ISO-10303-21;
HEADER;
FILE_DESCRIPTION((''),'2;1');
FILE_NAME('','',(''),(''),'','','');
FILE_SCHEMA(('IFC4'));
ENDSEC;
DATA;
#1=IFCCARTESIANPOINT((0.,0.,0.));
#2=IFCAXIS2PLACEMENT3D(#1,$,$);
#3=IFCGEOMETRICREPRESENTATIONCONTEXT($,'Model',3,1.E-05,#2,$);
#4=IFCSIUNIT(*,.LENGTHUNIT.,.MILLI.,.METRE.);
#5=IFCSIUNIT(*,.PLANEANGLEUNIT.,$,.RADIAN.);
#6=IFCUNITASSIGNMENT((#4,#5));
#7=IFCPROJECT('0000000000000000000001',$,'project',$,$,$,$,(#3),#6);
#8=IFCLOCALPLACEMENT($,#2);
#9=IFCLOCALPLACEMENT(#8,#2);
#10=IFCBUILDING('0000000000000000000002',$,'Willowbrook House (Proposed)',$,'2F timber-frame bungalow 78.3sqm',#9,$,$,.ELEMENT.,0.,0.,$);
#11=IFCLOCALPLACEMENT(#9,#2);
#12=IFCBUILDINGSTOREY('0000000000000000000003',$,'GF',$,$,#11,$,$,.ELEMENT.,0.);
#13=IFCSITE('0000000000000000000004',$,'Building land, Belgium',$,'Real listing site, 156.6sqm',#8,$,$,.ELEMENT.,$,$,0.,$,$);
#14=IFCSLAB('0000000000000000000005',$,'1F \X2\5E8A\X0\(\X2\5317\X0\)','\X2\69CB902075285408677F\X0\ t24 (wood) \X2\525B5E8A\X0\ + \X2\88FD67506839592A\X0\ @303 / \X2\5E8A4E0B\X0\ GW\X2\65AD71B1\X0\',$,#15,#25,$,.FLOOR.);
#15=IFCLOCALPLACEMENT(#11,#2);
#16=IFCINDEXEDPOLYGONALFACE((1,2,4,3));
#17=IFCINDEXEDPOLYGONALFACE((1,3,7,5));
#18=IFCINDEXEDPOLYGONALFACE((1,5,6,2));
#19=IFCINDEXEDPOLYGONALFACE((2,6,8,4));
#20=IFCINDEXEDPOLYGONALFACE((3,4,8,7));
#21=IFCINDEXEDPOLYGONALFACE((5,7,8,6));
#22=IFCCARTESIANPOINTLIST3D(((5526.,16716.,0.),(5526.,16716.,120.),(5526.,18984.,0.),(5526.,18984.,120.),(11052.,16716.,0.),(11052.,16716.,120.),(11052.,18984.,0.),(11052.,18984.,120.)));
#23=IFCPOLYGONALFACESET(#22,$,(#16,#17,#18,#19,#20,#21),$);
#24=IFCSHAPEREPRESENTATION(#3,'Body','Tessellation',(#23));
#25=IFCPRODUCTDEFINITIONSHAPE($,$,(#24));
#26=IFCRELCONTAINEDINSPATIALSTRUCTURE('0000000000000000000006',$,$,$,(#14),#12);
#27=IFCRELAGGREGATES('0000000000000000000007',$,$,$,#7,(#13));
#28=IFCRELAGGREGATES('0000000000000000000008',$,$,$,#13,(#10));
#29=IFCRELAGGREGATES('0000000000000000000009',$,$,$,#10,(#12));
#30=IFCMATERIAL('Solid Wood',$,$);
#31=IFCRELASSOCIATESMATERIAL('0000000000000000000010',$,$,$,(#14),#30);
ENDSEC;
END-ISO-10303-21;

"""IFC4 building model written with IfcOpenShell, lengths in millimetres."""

from ifc_helpers import new_model, si_unit, frame, frame_2d, origin, place, context, project, spatial, rectangle, extrude, material, element, save


model = new_model("IFC4")

# Units and contexts
model_context = context("Model", 3, precision=1e-05, world=origin())
ifc_project = project(units=[si_unit("LENGTHUNIT", "METRE", prefix="MILLI"), si_unit("PLANEANGLEUNIT", "RADIAN")], contexts=[model_context])

# Site, building, storey
site_placement = place(None, origin())
site = spatial("IfcSite", under=ifc_project, at=site_placement, Name="Building land, Belgium", ObjectType="Real listing site, 156.6sqm", CompositionType="ELEMENT", RefElevation=0.0)
building_placement = place(site_placement, origin())
building = spatial("IfcBuilding", under=site, at=building_placement, Name="Willowbrook House (Proposed)", ObjectType="2F timber-frame bungalow 78.3sqm", CompositionType="ELEMENT", ElevationOfRefHeight=0.0, ElevationOfTerrain=0.0)
storey_placement = place(building_placement, origin())
storey = spatial("IfcBuildingStorey", under=building, at=storey_placement, Name="GF", CompositionType="ELEMENT", Elevation=0.0)

# Slab
ifc_material_1 = material(Name="Solid Wood")
slab_1_placement = place(storey_placement, frame((2763.0, 8358.0, 0.0)))
element("IfcSlab", 1, at=slab_1_placement, inside=storey, material=ifc_material_1, Name="1F 床(北)", Description="構造用合板 t24 (wood) 剛床 + 製材根太 @303 / 床下 GW断熱", PredefinedType="FLOOR", context=model_context, shape_type="SweptSolid", body=[
    extrude(rectangle(XDim=5526.0, YDim=2268.0, at=frame_2d((2763.0, 1134.0))), frame((2763.0, 8358.0, 0.0)), (0.0, 0.0, 1.0), 120.0),
])

save(model, "model.ifc")
